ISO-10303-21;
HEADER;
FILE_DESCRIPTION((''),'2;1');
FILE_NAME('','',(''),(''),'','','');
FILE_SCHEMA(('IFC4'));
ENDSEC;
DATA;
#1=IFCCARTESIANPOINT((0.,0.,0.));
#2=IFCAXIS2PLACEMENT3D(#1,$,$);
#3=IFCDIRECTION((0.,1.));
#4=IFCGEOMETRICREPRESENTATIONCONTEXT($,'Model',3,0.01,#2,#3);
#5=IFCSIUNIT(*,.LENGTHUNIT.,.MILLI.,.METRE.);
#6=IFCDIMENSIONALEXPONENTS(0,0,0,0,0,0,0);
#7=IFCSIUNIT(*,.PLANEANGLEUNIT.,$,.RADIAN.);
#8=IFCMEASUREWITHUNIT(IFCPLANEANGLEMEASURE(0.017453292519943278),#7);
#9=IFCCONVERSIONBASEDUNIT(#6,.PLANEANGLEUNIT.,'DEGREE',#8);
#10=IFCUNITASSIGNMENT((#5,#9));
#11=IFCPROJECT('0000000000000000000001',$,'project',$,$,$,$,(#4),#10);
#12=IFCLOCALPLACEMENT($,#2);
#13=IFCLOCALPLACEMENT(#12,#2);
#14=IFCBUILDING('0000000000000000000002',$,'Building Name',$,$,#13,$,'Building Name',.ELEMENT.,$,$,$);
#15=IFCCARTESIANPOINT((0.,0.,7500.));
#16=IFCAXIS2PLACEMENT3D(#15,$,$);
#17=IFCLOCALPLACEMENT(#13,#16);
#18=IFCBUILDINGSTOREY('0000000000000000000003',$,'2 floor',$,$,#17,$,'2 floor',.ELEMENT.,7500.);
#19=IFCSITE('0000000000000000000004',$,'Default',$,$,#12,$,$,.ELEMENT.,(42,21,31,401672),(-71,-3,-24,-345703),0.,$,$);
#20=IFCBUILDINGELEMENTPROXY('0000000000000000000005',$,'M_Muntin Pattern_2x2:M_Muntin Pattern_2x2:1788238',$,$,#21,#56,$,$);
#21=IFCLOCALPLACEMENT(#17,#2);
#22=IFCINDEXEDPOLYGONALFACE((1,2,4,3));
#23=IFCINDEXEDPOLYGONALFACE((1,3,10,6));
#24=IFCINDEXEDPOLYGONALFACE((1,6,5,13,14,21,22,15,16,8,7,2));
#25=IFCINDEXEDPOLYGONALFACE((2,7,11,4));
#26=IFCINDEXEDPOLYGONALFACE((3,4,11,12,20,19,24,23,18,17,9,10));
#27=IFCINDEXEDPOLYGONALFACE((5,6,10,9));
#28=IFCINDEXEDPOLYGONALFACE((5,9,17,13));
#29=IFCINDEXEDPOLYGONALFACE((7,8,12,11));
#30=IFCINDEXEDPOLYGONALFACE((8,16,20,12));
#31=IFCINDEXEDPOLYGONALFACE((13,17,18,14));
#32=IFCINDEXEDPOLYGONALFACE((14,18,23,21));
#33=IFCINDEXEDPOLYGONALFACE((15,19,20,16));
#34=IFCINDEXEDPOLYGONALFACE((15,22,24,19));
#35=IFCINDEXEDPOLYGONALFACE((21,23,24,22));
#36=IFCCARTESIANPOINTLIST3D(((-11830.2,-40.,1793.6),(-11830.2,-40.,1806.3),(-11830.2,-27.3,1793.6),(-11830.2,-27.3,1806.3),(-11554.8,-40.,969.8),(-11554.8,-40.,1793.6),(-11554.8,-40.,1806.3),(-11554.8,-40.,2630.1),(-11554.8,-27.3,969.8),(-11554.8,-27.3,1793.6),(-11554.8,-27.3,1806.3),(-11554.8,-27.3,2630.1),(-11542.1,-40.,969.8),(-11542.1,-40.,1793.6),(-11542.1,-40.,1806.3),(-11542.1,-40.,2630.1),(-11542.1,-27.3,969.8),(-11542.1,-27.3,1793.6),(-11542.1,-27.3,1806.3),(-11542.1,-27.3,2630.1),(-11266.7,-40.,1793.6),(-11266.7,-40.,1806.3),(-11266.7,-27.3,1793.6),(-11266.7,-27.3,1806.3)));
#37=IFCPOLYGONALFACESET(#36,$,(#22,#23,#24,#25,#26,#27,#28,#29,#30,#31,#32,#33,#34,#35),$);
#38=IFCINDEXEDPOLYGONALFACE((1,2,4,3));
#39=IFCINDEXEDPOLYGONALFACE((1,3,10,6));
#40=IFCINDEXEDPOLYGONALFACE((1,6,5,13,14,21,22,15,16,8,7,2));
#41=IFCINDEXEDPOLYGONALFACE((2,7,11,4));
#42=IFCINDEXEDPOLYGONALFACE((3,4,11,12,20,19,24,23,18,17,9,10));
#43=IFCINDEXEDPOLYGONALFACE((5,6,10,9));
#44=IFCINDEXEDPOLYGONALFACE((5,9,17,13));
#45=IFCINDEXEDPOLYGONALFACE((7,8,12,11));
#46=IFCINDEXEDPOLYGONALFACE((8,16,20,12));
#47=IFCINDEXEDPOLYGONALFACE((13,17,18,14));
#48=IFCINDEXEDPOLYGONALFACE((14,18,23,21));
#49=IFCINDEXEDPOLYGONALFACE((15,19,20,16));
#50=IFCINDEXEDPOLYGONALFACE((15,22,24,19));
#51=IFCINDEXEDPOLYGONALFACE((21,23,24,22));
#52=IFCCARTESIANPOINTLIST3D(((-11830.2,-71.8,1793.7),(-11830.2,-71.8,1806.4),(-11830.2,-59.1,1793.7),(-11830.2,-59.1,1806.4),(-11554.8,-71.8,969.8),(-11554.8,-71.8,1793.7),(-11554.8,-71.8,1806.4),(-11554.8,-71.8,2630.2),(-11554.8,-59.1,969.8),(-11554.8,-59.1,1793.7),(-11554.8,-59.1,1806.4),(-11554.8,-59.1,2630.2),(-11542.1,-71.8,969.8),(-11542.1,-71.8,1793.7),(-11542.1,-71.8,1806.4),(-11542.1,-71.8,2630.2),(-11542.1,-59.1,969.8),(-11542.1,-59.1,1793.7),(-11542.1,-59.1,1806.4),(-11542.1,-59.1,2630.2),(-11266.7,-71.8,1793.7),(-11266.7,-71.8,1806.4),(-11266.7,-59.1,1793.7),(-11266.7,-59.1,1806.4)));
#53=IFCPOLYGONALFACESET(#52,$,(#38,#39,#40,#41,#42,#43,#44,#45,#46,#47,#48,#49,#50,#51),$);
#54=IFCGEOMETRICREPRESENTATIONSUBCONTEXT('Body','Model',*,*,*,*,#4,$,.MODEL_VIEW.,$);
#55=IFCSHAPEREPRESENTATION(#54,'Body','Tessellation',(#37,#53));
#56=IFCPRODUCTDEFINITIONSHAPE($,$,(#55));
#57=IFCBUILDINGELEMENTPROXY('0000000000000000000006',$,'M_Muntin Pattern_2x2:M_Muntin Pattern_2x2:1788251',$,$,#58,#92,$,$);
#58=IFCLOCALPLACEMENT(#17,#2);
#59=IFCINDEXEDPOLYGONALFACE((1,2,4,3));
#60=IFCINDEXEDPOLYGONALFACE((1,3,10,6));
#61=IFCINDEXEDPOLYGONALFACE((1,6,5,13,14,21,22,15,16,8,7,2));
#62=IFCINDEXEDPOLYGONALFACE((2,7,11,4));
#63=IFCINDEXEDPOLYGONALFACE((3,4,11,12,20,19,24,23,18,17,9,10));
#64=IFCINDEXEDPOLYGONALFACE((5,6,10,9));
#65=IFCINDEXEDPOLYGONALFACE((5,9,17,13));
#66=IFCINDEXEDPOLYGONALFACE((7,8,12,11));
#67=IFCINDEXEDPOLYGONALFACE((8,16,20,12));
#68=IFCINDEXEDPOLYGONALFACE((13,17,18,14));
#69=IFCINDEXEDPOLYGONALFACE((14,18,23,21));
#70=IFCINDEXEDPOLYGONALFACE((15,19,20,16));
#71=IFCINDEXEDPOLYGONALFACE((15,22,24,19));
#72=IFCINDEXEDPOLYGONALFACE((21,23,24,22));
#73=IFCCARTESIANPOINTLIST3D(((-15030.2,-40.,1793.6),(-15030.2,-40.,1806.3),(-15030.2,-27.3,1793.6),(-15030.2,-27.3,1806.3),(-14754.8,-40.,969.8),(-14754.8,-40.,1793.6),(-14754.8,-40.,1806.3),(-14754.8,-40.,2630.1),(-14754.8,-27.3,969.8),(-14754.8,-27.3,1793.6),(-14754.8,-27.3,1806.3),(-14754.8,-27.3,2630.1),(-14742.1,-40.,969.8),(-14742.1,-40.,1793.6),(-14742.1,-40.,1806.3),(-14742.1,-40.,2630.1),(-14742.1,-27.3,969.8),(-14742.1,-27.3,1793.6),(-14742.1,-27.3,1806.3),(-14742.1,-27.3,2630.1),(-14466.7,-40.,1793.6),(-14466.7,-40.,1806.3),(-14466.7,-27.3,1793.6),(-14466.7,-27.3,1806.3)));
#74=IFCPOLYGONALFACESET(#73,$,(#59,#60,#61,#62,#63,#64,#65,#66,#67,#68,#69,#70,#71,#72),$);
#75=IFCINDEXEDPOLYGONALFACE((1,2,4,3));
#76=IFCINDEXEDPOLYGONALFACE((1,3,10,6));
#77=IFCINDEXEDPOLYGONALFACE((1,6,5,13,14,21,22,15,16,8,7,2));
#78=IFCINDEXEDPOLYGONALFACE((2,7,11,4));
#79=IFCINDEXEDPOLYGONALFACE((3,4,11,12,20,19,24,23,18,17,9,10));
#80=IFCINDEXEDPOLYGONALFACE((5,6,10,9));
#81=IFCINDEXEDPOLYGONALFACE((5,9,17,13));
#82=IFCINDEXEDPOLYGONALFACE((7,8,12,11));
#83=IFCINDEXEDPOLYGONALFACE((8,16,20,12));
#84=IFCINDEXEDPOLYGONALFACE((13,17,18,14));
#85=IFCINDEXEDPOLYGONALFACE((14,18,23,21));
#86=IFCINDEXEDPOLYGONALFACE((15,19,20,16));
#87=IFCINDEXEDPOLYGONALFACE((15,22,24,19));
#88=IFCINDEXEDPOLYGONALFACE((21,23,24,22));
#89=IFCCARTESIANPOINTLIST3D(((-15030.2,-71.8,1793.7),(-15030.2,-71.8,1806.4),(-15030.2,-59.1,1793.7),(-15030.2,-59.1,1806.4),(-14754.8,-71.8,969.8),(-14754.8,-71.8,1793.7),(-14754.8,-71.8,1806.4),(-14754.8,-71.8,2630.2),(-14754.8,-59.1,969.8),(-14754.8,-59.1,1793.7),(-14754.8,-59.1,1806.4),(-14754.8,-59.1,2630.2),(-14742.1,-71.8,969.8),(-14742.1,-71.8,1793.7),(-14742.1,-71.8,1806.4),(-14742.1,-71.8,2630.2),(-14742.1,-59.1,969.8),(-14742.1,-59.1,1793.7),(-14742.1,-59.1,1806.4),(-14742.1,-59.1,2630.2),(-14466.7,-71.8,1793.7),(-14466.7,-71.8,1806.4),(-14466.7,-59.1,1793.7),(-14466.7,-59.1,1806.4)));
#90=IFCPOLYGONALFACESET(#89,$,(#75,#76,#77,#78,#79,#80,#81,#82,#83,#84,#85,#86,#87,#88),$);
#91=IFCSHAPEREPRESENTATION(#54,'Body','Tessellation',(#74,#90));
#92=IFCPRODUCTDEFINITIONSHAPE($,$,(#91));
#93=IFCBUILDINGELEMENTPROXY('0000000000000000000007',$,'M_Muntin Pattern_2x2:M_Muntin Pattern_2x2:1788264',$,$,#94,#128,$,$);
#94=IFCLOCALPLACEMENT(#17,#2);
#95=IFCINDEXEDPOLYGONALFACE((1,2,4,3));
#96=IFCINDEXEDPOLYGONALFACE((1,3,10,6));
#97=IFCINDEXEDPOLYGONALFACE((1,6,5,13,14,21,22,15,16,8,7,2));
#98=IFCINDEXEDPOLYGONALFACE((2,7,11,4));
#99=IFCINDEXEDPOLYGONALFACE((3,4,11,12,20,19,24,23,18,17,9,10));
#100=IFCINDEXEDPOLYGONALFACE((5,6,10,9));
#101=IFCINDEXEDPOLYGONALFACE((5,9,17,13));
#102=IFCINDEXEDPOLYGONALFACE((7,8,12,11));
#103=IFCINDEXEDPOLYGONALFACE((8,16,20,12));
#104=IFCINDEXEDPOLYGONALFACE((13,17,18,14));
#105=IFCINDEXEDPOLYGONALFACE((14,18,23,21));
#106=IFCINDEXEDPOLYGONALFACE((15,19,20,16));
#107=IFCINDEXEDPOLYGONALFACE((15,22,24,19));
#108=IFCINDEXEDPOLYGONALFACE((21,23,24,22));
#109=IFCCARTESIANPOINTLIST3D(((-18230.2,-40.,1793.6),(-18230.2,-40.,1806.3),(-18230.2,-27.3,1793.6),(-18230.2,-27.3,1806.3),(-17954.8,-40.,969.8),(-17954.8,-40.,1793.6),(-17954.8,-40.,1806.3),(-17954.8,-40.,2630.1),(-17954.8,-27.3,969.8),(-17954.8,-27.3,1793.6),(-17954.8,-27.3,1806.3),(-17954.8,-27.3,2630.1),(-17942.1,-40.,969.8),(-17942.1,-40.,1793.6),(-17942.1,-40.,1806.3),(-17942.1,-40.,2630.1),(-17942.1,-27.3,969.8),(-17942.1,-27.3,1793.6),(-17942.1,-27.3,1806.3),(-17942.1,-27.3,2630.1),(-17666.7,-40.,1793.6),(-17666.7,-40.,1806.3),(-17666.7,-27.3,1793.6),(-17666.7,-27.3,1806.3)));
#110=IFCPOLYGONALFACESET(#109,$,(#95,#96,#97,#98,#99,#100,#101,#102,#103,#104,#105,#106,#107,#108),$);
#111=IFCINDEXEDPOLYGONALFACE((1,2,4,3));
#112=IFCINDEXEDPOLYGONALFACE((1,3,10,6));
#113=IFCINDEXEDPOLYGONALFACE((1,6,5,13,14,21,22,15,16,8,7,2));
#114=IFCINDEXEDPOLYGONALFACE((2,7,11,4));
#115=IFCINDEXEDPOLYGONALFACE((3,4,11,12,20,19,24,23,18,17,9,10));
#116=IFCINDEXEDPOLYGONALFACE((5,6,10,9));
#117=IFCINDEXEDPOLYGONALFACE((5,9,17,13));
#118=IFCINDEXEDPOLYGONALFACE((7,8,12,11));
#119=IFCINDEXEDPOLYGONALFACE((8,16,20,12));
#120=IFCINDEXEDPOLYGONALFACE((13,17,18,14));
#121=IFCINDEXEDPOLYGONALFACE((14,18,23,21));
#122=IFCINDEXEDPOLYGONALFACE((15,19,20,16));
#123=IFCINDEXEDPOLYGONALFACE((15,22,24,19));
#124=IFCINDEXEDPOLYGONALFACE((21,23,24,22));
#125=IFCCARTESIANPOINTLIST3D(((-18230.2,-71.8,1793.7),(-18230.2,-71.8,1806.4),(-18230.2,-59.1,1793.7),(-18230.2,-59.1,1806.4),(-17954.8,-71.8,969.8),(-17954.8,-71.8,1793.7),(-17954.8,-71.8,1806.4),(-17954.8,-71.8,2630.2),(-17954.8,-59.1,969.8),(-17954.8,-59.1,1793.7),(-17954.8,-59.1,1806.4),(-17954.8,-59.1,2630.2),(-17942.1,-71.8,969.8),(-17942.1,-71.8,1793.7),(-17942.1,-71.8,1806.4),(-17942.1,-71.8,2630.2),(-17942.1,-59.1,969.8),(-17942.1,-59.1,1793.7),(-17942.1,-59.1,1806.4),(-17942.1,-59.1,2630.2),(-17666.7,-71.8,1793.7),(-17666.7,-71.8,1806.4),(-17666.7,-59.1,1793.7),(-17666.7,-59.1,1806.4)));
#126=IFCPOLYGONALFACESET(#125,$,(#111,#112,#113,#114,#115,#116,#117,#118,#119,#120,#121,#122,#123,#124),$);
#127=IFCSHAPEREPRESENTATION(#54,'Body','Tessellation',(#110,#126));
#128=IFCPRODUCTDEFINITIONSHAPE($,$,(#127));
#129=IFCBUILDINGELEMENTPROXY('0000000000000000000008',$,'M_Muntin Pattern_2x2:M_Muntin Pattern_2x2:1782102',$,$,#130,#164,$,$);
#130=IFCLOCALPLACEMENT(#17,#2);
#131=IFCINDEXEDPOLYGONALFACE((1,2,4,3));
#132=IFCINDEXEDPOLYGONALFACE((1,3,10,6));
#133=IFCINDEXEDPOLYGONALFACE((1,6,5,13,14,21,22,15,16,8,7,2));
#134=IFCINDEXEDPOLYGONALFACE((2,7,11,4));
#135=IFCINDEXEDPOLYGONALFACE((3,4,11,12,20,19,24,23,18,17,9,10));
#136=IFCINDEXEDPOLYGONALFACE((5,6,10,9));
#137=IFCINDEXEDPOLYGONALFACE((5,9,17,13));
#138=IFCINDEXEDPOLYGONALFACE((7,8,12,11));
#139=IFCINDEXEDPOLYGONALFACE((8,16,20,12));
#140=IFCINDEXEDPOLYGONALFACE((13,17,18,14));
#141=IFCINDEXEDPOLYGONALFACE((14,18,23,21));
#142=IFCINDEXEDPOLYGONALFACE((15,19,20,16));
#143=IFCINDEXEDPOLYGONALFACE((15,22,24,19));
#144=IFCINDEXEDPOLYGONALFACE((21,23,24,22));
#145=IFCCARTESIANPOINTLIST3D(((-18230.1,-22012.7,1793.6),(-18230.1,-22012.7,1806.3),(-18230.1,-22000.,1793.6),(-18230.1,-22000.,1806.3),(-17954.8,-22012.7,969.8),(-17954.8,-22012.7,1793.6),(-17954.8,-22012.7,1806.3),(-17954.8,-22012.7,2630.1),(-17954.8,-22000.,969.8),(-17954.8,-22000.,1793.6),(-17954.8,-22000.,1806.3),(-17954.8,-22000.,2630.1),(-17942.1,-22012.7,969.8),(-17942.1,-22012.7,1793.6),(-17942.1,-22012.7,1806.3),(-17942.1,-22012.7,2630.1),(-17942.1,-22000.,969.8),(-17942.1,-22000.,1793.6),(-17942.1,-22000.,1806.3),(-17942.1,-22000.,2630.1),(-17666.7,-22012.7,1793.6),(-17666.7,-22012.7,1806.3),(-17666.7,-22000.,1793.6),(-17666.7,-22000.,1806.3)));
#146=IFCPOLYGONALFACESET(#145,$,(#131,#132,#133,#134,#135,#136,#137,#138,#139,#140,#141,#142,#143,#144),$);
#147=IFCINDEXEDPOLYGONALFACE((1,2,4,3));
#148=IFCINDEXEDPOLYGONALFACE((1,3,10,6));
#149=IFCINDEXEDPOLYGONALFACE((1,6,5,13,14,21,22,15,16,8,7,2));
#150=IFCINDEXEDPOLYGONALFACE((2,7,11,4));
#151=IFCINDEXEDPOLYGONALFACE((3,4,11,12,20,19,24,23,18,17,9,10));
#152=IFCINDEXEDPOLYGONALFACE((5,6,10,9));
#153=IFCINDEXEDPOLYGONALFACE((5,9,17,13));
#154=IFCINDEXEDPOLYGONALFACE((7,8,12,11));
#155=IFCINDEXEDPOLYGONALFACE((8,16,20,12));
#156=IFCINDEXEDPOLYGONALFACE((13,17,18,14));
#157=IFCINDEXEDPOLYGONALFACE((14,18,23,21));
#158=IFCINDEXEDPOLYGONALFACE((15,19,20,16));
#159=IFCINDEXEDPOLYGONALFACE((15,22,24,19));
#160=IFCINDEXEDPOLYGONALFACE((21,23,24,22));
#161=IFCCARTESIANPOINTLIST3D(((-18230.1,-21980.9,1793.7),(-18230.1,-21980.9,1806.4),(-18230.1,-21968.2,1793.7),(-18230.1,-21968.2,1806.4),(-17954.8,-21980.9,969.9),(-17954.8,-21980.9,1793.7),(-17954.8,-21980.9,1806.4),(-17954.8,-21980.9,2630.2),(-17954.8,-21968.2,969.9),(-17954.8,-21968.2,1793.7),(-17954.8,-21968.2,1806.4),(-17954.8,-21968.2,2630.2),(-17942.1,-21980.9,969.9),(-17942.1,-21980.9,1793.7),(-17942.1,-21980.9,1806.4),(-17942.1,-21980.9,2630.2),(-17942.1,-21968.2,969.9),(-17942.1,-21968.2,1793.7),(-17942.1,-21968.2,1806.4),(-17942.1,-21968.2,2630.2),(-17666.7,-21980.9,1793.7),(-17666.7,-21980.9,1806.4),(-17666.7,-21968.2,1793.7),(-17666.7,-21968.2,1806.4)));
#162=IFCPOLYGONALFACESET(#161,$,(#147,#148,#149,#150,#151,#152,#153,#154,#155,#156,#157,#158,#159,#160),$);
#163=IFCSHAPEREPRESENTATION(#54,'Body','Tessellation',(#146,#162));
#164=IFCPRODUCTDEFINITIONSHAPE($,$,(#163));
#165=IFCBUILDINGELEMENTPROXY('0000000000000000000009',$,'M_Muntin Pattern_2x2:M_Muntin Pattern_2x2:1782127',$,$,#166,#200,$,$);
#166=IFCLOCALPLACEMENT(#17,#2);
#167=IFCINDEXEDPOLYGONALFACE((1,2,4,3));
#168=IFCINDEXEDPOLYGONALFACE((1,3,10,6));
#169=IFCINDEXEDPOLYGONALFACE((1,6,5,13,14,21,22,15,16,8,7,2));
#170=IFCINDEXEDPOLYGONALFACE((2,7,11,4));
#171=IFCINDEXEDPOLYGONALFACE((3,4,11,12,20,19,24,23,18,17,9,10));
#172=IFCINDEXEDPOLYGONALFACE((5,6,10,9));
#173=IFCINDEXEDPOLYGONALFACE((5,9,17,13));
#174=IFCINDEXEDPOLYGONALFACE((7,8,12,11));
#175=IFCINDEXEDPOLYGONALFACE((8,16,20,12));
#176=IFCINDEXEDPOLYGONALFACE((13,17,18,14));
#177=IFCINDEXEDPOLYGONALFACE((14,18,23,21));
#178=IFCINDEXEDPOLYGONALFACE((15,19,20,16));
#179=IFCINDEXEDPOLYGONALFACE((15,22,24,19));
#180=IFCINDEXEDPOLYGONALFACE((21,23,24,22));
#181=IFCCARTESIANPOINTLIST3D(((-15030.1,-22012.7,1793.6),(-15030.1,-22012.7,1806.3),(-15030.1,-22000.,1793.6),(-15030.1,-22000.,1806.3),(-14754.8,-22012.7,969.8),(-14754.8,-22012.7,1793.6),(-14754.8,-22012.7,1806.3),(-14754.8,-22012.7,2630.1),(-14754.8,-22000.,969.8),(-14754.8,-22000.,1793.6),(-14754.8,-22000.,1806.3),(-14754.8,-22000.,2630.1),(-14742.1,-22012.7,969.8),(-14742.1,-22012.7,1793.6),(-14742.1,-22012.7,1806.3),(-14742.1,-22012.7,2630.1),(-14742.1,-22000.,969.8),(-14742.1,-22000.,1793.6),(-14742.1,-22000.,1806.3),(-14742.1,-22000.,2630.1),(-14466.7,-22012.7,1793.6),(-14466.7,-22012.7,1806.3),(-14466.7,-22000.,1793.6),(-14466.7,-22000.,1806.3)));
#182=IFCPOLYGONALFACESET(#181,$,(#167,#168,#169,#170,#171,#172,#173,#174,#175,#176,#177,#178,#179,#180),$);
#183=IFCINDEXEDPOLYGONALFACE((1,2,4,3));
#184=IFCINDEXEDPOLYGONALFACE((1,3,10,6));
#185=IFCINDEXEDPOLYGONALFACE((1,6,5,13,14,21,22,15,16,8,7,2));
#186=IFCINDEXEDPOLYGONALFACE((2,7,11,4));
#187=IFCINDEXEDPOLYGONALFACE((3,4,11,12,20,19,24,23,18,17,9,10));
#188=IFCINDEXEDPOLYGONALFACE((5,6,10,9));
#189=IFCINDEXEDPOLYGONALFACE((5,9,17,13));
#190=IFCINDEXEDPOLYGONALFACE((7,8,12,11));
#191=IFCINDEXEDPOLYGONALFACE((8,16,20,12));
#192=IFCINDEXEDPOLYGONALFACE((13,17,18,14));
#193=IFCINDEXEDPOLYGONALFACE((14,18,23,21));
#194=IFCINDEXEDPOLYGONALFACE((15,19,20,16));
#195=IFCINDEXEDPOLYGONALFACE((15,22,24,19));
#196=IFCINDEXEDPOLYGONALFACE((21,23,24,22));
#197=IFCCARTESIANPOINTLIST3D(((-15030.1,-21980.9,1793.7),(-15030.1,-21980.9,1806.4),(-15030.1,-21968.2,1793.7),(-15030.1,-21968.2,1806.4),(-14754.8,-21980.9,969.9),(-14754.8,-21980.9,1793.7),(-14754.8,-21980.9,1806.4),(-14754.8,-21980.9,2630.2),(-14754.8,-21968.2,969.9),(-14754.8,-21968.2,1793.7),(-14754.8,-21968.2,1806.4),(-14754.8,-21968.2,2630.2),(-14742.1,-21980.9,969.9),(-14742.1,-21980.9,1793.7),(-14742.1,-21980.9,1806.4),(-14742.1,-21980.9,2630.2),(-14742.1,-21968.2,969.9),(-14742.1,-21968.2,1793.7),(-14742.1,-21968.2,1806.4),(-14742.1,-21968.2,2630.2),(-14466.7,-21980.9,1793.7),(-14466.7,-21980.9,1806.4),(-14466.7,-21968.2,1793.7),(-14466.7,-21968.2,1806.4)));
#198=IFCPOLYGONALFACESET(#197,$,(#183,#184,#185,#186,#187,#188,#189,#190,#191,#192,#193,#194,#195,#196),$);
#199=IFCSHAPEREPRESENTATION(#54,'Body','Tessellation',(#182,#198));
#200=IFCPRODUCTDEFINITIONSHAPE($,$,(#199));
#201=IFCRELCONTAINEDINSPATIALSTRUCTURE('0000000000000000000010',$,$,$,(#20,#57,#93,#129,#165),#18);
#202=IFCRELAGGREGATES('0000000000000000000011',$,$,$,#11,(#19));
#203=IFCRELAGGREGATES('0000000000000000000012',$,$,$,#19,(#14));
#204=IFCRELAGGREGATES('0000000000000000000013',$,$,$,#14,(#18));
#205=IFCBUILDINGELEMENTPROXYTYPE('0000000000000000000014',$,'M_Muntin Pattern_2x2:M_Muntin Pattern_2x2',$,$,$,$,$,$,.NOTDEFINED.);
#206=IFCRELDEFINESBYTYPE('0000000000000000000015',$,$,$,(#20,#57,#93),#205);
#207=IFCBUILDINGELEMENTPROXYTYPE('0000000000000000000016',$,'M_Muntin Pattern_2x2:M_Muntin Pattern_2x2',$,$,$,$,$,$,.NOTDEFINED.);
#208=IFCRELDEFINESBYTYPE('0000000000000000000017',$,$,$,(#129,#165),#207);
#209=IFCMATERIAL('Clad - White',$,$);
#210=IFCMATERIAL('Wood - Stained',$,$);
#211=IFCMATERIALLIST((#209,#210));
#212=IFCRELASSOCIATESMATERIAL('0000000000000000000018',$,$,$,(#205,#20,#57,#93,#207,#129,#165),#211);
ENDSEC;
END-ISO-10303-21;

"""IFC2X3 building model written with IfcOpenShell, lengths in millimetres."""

from ifc_helpers import new_model, entity, si_unit, converted_unit, direction, frame, origin, place, context, subcontext, project, spatial, polyline, outline, extrude, source, transform, mapped, material, material_list, type_object, type_shapes, element, save


model = new_model("IFC2X3")

# Units and contexts
model_context = context("Model", 3, precision=0.01, world=origin(), true_north=direction((0.0, 1.0)))
body_context = subcontext(model_context, "Body", "Model", "MODEL_VIEW")
ifc_project = project(units=[si_unit("LENGTHUNIT", "METRE", prefix="MILLI"), converted_unit("PLANEANGLEUNIT", "DEGREE", entity("IfcPlaneAngleMeasure", 0.017453292519943278), si_unit("PLANEANGLEUNIT", "RADIAN"), dimensions=[0, 0, 0, 0, 0, 0, 0])], contexts=[model_context])

# Site, building, storey
site_placement = place(None, origin())
site = spatial("IfcSite", under=ifc_project, at=site_placement, Name="Default", CompositionType="ELEMENT", RefLatitude=(42, 21, 31, 401672), RefLongitude=(-71, -3, -24, -345703), RefElevation=0.0)
building_placement = place(site_placement, origin())
building = spatial("IfcBuilding", under=site, at=building_placement, Name="Building Name", LongName="Building Name", CompositionType="ELEMENT")
storey_placement = place(building_placement, frame((0.0, 0.0, 7500.0)))
storey = spatial("IfcBuildingStorey", under=building, at=storey_placement, Name="2 floor", LongName="2 floor", CompositionType="ELEMENT", Elevation=7500.0)

# Building element proxies
ifc_material_1 = material(Name="Clad - White")
ifc_material_2 = material(Name="Wood - Stained")
ifc_material_list = material_list([ifc_material_1, ifc_material_2])
building_element_proxy_type_1 = type_object("IfcBuildingElementProxyType", Name="M_Muntin Pattern_2x2:M_Muntin Pattern_2x2", PredefinedType="NOTDEFINED", material=ifc_material_list)
shared_shape_1 = source(origin(), body_context, "Body", "SweptSolid", [
    extrude(outline(polyline([(6.4, -6.4), (830.1, -6.4), (830.1, 6.3), (6.4, 6.3), (6.4, 281.7), (-6.3, 281.7), (-6.3, 6.3), (-830.2, 6.3), (-830.2, -6.4), (-6.3, -6.4), (-6.3, -281.7), (6.4, -281.7), (6.4, -6.4)])), frame((0.0, 9.5, 830.1), z_axis=(0.0, 1.0, 0.0), x_axis=(0.0, 0.0, 1.0)), (0.0, 0.0, 1.0), 12.7),
    extrude(outline(polyline([(6.4, -6.4), (830.2, -6.4), (830.2, 6.3), (6.4, 6.3), (6.4, 281.7), (-6.3, 281.7), (-6.3, 6.3), (-830.2, 6.3), (-830.2, -6.4), (-6.3, -6.4), (-6.3, -281.7), (6.4, -281.7), (6.4, -6.4)])), frame((0.0, -22.2, 830.2), z_axis=(0.0, 1.0, 0.0), x_axis=(0.0, 0.0, 1.0)), (0.0, 0.0, 1.0), 12.7),
])
type_shapes(building_element_proxy_type_1, [shared_shape_1])
for number, where, name in (
    (1, (-11548.4, -49.5, 969.8), "M_Muntin Pattern_2x2:M_Muntin Pattern_2x2:1788238"),
    (2, (-14748.4, -49.5, 969.8), "M_Muntin Pattern_2x2:M_Muntin Pattern_2x2:1788251"),
    (3, (-17948.4, -49.5, 969.8), "M_Muntin Pattern_2x2:M_Muntin Pattern_2x2:1788264"),
):
    element("IfcBuildingElementProxy", number, at=place(storey_placement, frame(where)), inside=storey, type_object=building_element_proxy_type_1, material=ifc_material_list, Name=name, context=body_context, shape_type="MappedRepresentation", body=[
        mapped(shared_shape_1, transform((0.0, 0.0, 0.0), scale=1.0)),
    ])
building_element_proxy_type_2 = type_object("IfcBuildingElementProxyType", Name="M_Muntin Pattern_2x2:M_Muntin Pattern_2x2", PredefinedType="NOTDEFINED", material=ifc_material_list)
shared_shape_2 = source(origin(), body_context, "Body", "SweptSolid", [
    extrude(outline(polyline([(6.4, -6.4), (830.1, -6.4), (830.1, 6.3), (6.4, 6.3), (6.4, 281.7), (-6.3, 281.7), (-6.3, 6.3), (-830.2, 6.3), (-830.2, -6.4), (-6.3, -6.4), (-6.3, -281.7), (6.4, -281.7), (6.4, -6.4)])), frame((0.0, -22.2, 830.1), z_axis=(0.0, 1.0, 0.0), x_axis=(0.0, 0.0, 1.0)), (0.0, 0.0, 1.0), 12.7),
    extrude(outline(polyline([(6.4, -6.4), (830.2, -6.4), (830.2, 6.3), (6.4, 6.3), (6.4, 281.7), (-6.3, 281.7), (-6.3, 6.3), (-830.2, 6.3), (-830.2, -6.4), (-6.3, -6.4), (-6.3, -281.7), (6.4, -281.7), (6.4, -6.4)])), frame((0.0, 9.5, 830.2), z_axis=(0.0, 1.0, 0.0), x_axis=(0.0, 0.0, 1.0)), (0.0, 0.0, 1.0), 12.7),
])
type_shapes(building_element_proxy_type_2, [shared_shape_2])
for number, where, name in (
    (4, (-17948.4, -21990.5, 969.9), "M_Muntin Pattern_2x2:M_Muntin Pattern_2x2:1782102"),
    (5, (-14748.4, -21990.5, 969.9), "M_Muntin Pattern_2x2:M_Muntin Pattern_2x2:1782127"),
):
    element("IfcBuildingElementProxy", number, at=place(storey_placement, frame(where)), inside=storey, type_object=building_element_proxy_type_2, material=ifc_material_list, Name=name, context=body_context, shape_type="MappedRepresentation", body=[
        mapped(shared_shape_2, transform((0.0, 0.0, 0.0), scale=1.0)),
    ])

save(model, "model.ifc")
